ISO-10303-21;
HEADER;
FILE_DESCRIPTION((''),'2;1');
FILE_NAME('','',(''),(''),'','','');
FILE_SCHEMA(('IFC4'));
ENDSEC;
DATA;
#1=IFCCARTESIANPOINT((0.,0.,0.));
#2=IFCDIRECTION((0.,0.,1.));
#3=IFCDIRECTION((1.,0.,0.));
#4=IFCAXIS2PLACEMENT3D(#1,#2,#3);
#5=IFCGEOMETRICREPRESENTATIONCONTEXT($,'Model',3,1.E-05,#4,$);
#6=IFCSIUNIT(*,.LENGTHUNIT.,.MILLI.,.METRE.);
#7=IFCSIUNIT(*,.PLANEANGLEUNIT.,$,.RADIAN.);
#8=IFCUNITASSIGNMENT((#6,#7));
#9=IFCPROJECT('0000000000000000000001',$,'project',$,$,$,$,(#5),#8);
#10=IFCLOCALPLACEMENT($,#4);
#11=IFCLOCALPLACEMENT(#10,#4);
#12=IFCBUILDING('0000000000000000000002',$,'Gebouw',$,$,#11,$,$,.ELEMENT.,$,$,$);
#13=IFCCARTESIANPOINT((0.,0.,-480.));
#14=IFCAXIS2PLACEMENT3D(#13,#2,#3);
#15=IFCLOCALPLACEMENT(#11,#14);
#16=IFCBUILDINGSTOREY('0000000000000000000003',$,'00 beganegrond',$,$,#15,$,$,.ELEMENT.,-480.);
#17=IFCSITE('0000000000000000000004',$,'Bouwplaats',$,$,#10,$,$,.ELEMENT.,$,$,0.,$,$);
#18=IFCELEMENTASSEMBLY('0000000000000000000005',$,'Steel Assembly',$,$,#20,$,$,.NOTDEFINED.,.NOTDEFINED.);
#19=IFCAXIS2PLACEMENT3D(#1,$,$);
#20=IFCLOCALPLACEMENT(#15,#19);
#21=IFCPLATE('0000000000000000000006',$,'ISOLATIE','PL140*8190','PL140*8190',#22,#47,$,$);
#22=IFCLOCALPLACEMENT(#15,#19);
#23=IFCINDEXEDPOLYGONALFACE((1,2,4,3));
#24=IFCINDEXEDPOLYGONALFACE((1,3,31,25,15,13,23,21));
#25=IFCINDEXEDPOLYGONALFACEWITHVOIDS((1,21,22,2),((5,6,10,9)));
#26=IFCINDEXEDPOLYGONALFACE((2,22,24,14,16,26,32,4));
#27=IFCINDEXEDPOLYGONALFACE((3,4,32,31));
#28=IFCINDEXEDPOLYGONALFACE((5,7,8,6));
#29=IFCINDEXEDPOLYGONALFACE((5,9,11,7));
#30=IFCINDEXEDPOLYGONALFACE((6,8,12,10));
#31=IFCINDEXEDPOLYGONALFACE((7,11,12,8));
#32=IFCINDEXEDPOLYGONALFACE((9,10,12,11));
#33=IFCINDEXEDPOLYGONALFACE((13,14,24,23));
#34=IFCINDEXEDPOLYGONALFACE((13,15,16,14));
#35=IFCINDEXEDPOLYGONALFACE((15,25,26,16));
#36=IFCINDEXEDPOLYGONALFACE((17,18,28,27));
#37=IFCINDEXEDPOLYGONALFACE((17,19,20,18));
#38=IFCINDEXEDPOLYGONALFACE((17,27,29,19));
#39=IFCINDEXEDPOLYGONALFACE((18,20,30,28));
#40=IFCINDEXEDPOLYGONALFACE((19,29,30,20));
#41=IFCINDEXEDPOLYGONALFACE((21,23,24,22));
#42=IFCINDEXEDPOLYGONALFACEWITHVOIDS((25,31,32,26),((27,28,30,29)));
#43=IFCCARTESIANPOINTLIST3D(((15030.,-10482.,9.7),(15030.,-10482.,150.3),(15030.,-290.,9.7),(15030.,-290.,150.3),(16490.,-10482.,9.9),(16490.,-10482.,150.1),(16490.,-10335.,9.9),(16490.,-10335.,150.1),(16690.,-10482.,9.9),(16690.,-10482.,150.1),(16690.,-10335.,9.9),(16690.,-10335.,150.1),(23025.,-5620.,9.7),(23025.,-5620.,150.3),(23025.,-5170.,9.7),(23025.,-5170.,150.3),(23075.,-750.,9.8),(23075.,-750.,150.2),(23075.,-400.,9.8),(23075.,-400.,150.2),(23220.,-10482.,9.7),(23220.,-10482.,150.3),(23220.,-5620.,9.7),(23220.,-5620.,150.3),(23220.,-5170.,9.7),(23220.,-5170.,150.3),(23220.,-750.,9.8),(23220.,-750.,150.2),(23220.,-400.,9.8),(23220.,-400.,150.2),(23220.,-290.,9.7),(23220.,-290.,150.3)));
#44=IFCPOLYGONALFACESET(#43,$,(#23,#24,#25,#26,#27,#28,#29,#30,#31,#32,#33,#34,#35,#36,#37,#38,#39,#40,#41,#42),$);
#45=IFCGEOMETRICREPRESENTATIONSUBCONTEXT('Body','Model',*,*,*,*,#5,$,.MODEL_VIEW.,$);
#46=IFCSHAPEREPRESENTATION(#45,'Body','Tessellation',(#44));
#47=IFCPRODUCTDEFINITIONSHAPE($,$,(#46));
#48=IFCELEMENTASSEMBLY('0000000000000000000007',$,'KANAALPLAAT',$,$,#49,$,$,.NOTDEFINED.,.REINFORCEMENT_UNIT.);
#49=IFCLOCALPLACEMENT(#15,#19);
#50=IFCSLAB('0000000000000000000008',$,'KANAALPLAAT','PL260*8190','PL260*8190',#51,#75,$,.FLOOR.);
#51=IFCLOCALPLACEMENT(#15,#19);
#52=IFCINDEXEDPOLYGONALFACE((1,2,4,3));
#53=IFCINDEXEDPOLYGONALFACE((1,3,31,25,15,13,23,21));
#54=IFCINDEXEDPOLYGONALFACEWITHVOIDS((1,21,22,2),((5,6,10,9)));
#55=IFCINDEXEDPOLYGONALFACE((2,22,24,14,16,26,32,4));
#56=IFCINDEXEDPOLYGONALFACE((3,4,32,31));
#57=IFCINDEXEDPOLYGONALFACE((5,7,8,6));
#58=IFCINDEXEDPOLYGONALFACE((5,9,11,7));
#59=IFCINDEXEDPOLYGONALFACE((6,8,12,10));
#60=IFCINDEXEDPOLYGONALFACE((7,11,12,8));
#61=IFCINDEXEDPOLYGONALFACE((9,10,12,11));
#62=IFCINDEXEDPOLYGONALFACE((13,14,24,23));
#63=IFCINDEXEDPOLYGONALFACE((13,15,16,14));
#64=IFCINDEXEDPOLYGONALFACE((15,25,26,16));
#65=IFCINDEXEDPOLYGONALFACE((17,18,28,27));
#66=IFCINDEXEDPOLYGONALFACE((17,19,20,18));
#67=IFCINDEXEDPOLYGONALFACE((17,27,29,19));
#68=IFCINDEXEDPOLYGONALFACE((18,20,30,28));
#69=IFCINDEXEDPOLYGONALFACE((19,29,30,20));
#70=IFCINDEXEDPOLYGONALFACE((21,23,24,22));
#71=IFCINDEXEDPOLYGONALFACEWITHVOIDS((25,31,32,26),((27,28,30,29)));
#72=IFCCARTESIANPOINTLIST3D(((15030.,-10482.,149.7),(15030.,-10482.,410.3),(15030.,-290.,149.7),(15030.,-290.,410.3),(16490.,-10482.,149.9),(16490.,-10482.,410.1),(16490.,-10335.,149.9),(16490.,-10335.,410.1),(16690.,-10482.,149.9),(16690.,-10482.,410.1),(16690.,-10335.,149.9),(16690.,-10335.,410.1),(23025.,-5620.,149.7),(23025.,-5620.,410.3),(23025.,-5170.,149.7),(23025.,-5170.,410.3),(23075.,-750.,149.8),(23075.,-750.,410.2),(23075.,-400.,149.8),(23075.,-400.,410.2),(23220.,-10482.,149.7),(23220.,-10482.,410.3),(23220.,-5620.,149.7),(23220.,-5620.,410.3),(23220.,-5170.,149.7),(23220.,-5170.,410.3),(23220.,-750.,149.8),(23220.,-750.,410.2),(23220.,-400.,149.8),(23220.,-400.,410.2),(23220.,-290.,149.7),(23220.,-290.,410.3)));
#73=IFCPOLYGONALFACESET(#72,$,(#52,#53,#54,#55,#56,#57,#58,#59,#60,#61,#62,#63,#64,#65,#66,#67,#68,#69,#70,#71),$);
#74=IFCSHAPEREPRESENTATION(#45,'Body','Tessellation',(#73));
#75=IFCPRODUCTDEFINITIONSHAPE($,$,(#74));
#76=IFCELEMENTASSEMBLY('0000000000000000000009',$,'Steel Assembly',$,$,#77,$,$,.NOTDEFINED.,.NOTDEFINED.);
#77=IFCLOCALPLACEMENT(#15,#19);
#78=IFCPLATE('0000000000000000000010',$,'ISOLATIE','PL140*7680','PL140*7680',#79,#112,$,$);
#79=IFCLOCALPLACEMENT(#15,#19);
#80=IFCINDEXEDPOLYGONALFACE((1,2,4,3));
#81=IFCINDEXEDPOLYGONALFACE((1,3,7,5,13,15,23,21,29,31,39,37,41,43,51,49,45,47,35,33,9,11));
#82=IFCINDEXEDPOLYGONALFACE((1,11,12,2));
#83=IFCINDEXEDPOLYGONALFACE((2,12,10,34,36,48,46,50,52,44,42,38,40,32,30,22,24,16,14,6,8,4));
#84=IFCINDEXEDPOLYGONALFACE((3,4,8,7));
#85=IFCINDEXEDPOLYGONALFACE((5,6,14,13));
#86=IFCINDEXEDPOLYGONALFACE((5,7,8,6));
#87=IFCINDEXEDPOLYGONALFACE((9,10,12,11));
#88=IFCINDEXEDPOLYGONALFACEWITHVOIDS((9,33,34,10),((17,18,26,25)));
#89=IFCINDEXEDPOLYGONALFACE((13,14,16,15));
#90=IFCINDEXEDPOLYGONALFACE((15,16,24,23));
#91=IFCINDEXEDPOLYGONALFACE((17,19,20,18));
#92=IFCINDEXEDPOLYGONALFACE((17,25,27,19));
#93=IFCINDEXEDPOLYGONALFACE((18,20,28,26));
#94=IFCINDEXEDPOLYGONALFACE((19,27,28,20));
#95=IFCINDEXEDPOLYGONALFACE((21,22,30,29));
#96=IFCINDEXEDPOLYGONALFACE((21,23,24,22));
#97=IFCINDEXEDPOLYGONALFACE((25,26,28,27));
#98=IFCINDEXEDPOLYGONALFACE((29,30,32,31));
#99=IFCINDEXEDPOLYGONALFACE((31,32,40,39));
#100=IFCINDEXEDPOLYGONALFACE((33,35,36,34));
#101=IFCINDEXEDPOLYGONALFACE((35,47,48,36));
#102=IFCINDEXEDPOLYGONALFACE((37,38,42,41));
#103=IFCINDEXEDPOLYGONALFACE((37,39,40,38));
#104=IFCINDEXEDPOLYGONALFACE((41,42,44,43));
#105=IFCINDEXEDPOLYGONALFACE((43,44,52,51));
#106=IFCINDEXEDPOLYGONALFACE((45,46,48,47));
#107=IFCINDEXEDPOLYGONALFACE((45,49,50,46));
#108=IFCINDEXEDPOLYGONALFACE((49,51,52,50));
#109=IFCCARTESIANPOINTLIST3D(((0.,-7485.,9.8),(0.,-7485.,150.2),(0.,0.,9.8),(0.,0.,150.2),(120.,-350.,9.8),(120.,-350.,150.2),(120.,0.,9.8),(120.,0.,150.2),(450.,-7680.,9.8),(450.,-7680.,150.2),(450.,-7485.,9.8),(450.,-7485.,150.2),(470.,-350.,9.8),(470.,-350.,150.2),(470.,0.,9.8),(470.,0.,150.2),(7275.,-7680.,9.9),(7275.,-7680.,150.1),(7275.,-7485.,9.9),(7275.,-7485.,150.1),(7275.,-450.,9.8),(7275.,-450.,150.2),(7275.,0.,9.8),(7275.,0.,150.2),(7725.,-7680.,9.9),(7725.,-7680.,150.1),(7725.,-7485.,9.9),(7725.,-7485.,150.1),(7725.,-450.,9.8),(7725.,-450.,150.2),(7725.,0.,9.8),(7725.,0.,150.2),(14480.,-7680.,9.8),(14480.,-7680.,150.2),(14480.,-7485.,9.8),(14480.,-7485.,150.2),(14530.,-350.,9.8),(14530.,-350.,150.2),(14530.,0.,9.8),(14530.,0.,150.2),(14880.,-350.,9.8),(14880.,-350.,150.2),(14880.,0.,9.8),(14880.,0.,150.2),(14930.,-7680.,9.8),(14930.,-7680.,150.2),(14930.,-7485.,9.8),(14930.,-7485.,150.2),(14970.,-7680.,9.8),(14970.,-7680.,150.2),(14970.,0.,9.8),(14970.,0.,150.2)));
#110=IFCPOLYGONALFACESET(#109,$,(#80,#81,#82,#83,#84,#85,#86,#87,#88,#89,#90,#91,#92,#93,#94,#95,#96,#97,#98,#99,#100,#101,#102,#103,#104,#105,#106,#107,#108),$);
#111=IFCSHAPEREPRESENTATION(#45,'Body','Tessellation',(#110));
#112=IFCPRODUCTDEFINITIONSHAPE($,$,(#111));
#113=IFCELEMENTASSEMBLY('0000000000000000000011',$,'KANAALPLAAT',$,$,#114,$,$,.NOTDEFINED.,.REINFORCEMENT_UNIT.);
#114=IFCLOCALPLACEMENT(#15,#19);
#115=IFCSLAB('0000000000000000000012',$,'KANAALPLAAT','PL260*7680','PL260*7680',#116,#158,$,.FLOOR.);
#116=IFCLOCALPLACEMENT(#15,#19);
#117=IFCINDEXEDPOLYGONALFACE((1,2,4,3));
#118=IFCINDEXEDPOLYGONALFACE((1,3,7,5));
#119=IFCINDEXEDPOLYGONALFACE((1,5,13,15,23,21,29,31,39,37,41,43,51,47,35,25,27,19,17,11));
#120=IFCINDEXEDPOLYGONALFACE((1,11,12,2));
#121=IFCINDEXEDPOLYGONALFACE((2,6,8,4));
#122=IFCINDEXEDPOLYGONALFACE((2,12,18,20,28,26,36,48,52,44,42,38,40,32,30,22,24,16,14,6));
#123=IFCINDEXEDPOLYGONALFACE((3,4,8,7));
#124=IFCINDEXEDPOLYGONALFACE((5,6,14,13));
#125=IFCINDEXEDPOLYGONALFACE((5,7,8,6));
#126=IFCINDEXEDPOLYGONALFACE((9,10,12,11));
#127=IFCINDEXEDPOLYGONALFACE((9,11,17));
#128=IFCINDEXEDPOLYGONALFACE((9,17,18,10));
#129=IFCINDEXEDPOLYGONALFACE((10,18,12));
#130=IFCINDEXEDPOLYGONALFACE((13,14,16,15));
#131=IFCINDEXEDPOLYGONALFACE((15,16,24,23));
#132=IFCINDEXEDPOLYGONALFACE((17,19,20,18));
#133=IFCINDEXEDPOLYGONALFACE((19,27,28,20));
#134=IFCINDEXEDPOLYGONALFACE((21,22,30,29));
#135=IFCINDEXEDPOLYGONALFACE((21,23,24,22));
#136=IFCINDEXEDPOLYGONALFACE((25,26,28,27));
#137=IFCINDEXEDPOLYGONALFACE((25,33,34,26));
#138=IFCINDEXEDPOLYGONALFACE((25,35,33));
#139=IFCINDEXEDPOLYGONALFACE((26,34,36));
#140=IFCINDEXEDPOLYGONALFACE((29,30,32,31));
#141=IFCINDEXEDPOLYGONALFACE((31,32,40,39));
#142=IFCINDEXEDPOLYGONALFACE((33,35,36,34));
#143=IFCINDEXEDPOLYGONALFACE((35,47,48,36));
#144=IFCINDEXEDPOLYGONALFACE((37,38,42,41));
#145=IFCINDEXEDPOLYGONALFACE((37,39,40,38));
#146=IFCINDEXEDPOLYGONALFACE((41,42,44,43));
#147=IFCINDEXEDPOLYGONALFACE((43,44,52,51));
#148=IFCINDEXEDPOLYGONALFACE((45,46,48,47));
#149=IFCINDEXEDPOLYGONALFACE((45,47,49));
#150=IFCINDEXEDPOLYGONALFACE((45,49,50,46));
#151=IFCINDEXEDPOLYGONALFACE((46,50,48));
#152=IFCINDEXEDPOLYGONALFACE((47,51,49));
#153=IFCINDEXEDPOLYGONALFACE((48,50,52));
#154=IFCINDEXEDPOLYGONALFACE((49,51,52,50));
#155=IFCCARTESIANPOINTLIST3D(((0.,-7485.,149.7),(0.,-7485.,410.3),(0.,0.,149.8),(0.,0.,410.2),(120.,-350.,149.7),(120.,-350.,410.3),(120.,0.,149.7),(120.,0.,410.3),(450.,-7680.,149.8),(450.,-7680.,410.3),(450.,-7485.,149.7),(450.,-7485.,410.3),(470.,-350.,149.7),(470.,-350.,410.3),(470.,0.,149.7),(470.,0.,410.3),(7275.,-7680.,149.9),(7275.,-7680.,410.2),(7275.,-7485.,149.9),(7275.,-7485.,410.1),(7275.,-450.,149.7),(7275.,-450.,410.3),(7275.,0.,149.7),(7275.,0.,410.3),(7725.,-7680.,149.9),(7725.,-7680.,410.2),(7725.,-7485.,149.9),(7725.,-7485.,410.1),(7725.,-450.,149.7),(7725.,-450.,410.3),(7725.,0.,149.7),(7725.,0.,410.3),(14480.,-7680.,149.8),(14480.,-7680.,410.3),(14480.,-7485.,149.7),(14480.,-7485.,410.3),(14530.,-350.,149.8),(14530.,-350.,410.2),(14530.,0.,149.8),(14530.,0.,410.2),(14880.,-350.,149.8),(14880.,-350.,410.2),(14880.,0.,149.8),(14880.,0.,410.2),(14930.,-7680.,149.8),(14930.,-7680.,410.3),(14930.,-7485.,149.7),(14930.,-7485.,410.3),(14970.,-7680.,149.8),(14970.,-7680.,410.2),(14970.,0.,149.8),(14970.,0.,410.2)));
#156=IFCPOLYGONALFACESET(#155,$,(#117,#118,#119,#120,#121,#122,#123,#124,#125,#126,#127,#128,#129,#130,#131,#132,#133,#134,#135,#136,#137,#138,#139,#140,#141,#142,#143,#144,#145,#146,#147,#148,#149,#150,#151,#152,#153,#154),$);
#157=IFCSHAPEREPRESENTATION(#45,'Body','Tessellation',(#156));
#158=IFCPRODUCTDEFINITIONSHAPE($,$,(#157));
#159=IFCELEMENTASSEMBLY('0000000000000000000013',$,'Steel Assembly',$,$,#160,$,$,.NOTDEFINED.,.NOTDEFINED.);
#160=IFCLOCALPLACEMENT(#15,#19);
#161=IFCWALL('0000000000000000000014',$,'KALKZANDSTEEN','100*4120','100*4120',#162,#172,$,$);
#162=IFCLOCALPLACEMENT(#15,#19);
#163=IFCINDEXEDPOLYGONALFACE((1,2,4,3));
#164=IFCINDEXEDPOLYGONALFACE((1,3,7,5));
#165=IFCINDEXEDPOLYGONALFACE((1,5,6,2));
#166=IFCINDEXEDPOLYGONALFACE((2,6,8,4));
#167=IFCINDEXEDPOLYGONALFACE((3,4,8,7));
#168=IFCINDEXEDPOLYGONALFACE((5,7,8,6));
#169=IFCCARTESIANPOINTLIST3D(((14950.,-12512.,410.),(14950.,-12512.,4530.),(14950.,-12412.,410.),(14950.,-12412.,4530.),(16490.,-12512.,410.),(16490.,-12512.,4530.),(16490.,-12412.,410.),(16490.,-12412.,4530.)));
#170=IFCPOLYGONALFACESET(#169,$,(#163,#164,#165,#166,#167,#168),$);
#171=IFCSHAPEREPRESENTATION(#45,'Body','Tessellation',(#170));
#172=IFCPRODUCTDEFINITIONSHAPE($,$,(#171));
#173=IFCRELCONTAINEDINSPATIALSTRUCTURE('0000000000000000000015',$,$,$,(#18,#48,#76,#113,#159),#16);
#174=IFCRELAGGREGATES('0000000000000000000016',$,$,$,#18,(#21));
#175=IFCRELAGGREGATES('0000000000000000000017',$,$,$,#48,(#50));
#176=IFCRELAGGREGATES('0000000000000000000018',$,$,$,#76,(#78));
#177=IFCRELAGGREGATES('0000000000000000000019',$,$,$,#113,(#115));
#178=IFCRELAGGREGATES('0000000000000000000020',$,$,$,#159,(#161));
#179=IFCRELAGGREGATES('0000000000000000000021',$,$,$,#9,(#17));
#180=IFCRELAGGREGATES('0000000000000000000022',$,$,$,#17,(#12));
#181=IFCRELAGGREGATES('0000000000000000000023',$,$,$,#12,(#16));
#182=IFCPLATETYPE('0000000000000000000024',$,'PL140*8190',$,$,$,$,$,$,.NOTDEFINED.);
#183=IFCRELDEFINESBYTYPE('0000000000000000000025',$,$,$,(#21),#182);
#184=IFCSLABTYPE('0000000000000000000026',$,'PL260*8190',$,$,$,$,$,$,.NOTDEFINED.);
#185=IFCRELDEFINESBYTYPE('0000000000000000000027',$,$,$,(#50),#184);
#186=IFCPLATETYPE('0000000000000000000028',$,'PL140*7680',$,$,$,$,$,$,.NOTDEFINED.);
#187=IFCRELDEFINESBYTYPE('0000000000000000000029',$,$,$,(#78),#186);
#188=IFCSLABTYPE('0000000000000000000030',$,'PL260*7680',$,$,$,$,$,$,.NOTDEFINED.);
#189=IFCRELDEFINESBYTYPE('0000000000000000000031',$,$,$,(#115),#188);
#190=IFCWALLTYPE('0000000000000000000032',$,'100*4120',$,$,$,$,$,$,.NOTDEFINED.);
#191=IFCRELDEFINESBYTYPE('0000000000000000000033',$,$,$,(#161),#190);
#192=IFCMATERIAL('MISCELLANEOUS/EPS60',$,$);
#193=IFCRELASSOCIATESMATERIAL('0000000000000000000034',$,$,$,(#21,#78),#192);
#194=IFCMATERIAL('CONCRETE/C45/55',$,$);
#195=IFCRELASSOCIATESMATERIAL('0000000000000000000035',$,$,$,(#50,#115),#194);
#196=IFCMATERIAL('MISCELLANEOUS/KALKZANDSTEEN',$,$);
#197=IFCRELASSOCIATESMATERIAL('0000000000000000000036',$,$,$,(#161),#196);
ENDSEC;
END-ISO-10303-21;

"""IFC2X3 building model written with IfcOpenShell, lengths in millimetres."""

from ifc_helpers import new_model, si_unit, frame, frame_2d, origin_with_axes, place, context, subcontext, project, spatial, polyline, rectangle, outline, extrude, boolean, material, type_object, element, aggregate, save


model = new_model("IFC2X3")

# Units and contexts
model_context = context("Model", 3, precision=1e-05, world=origin_with_axes())
body_context = subcontext(model_context, "Body", "Model", "MODEL_VIEW")
ifc_project = project(units=[si_unit("LENGTHUNIT", "METRE", prefix="MILLI"), si_unit("PLANEANGLEUNIT", "RADIAN")], contexts=[model_context])

# Site, building, storey
site_placement = place(None, origin_with_axes())
site = spatial("IfcSite", under=ifc_project, at=site_placement, Name="Bouwplaats", CompositionType="ELEMENT", RefElevation=0.0)
building_placement = place(site_placement, origin_with_axes())
building = spatial("IfcBuilding", under=site, at=building_placement, Name="Gebouw", CompositionType="ELEMENT")
storey_placement = place(building_placement, frame((0.0, 0.0, -480.0), z_axis=(0.0, 0.0, 1.0), x_axis=(1.0, 0.0, 0.0)))
storey = spatial("IfcBuildingStorey", under=building, at=storey_placement, Name="00 beganegrond", CompositionType="ELEMENT", Elevation=-480.0)

# Element assembly, plate
assembly_1_placement = place(storey_placement, origin_with_axes())
assembly_1 = element("IfcElementAssembly", 1, at=assembly_1_placement, inside=storey, Name="Steel Assembly", AssemblyPlace="NOTDEFINED", PredefinedType="NOTDEFINED")
ifc_material_1 = material(Name="MISCELLANEOUS/EPS60")
plate_type_1 = type_object("IfcPlateType", Name="PL140*8190", PredefinedType="NOTDEFINED")
plate_1_placement = place(assembly_1_placement, frame((15030.0, -10482.0, 80.0), z_axis=(0.0, 0.0, 1.0), x_axis=(1.0, 0.0, 0.0)))
plate_1 = element("IfcPlate", 2, at=plate_1_placement, type_object=plate_type_1, material=ifc_material_1, Name="ISOLATIE", Description="PL140*8190", ObjectType="PL140*8190", context=body_context, shape_type="CSG", body=[
    boolean("DIFFERENCE", boolean("DIFFERENCE", boolean("DIFFERENCE", extrude(outline(polyline([(0.0, 0.0), (8190.0, 0.0), (8190.0, 10192.0), (0.0, 10192.0), (0.0, 0.0)])), frame((0.0, 0.0, -70.3), z_axis=(0.0, 0.0, 1.0), x_axis=(1.0, 0.0, 0.0)), (0.0, 0.0, 1.0), 140.6), extrude(outline(polyline([(0.0, 0.0), (450.0, 0.0), (450.0, 450.0), (0.0, 450.0), (0.0, 0.0)])), frame((7995.0, 5312.0, -70.3), z_axis=(0.0, 0.0, 1.0), x_axis=(0.0, -1.0, 0.0)), (0.0, 0.0, 1.0), 140.6)), extrude(outline(polyline([(0.0, 0.0), (350.0, 0.0), (350.0, 350.0), (0.0, 350.0), (0.0, 0.0)])), frame((8045.0, 10082.0, -70.2), z_axis=(0.0, 0.0, 1.0), x_axis=(0.0, -1.0, 0.0)), (0.0, 0.0, 1.0), 140.4)), extrude(outline(polyline([(0.0, 0.0), (6835.0, 0.0), (6835.0, 200.0), (0.0, 200.0), (0.0, 0.0)])), frame((1460.0, 147.0, -70.1), z_axis=(0.0, 0.0, 1.0), x_axis=(0.0, -1.0, 0.0)), (0.0, 0.0, 1.0), 140.2)),
])
aggregate(assembly_1, [plate_1])

# Element assembly, slab
assembly_2_placement = place(storey_placement, origin_with_axes())
assembly_2 = element("IfcElementAssembly", 3, at=assembly_2_placement, inside=storey, Name="KANAALPLAAT", AssemblyPlace="NOTDEFINED", PredefinedType="REINFORCEMENT_UNIT")
ifc_material_2 = material(Name="CONCRETE/C45/55")
slab_type_1 = type_object("IfcSlabType", Name="PL260*8190", PredefinedType="NOTDEFINED")
slab_1_placement = place(assembly_2_placement, frame((15030.0, -10482.0, 280.0), z_axis=(0.0, 0.0, 1.0), x_axis=(1.0, 0.0, 0.0)))
slab_1 = element("IfcSlab", 4, at=slab_1_placement, type_object=slab_type_1, material=ifc_material_2, Name="KANAALPLAAT", Description="PL260*8190", ObjectType="PL260*8190", PredefinedType="FLOOR", context=body_context, shape_type="CSG", body=[
    boolean("DIFFERENCE", boolean("DIFFERENCE", boolean("DIFFERENCE", extrude(outline(polyline([(0.0, 0.0), (8190.0, 0.0), (8190.0, 10192.0), (0.0, 10192.0), (0.0, 0.0)])), frame((0.0, 0.0, -130.3), z_axis=(0.0, 0.0, 1.0), x_axis=(1.0, 0.0, 0.0)), (0.0, 0.0, 1.0), 260.6), extrude(outline(polyline([(0.0, 0.0), (450.0, 0.0), (450.0, 450.0), (0.0, 450.0), (0.0, 0.0)])), frame((7995.0, 5312.0, -130.3), z_axis=(0.0, 0.0, 1.0), x_axis=(0.0, -1.0, 0.0)), (0.0, 0.0, 1.0), 260.6)), extrude(outline(polyline([(0.0, 0.0), (350.0, 0.0), (350.0, 350.0), (0.0, 350.0), (0.0, 0.0)])), frame((8045.0, 10082.0, -130.2), z_axis=(0.0, 0.0, 1.0), x_axis=(0.0, -1.0, 0.0)), (0.0, 0.0, 1.0), 260.4)), extrude(outline(polyline([(0.0, 0.0), (6835.0, 0.0), (6835.0, 200.0), (0.0, 200.0), (0.0, 0.0)])), frame((1460.0, 147.0, -130.1), z_axis=(0.0, 0.0, 1.0), x_axis=(0.0, -1.0, 0.0)), (0.0, 0.0, 1.0), 260.2)),
])
aggregate(assembly_2, [slab_1])

# Element assembly, plate
assembly_3_placement = place(storey_placement, origin_with_axes())
assembly_3 = element("IfcElementAssembly", 5, at=assembly_3_placement, inside=storey, Name="Steel Assembly", AssemblyPlace="NOTDEFINED", PredefinedType="NOTDEFINED")
plate_type_2 = type_object("IfcPlateType", Name="PL140*7680", PredefinedType="NOTDEFINED")
plate_2_placement = place(assembly_3_placement, frame((14970.0, -7680.0, 80.0), z_axis=(0.0, 0.0, 1.0), x_axis=(0.0, 1.0, 0.0)))
plate_2 = element("IfcPlate", 6, at=plate_2_placement, type_object=plate_type_2, material=ifc_material_1, Name="ISOLATIE", Description="PL140*7680", ObjectType="PL140*7680", context=body_context, shape_type="CSG", body=[
    boolean("DIFFERENCE", boolean("DIFFERENCE", boolean("DIFFERENCE", boolean("DIFFERENCE", boolean("DIFFERENCE", boolean("DIFFERENCE", extrude(outline(polyline([(0.0, 0.0), (7680.0, 0.0), (7680.0, 14970.0), (0.0, 14970.0), (0.0, 0.0)])), frame((0.0, 0.0, -70.2), z_axis=(0.0, 0.0, 1.0), x_axis=(1.0, 0.0, 0.0)), (0.0, 0.0, 1.0), 140.4), extrude(outline(polyline([(0.0, 0.0), (450.0, 0.0), (450.0, 450.0), (0.0, 450.0), (0.0, 0.0)])), frame((-255.0, 7695.0, -70.1), z_axis=(0.0, 0.0, 1.0), x_axis=(0.0, -1.0, 0.0)), (0.0, 0.0, 1.0), 140.2)), extrude(outline(polyline([(0.0, 0.0), (350.0, 0.0), (350.0, 350.0), (0.0, 350.0), (0.0, 0.0)])), frame((7330.0, 440.0, -70.2), z_axis=(0.0, 0.0, 1.0), x_axis=(0.0, -1.0, 0.0)), (0.0, 0.0, 1.0), 140.4)), extrude(outline(polyline([(0.0, 0.0), (450.0, 0.0), (450.0, 450.0), (0.0, 450.0), (0.0, 0.0)])), frame((7230.0, 7695.0, -70.3), z_axis=(0.0, 0.0, 1.0), x_axis=(0.0, -1.0, 0.0)), (0.0, 0.0, 1.0), 140.6)), extrude(outline(polyline([(0.0, 0.0), (350.0, 0.0), (350.0, 350.0), (0.0, 350.0), (0.0, 0.0)])), frame((7330.0, 14850.0, -70.3), z_axis=(0.0, 0.0, 1.0), x_axis=(0.0, -1.0, 0.0)), (0.0, 0.0, 1.0), 140.6)), extrude(outline(polyline([(0.0, 0.0), (450.0, 0.0), (450.0, 450.0), (0.0, 450.0), (0.0, 0.0)])), frame((-255.0, 14970.0, -70.3), z_axis=(0.0, 0.0, 1.0), x_axis=(0.0, -1.0, 0.0)), (0.0, 0.0, 1.0), 140.6)), extrude(outline(polyline([(0.0, 0.0), (450.0, 0.0), (450.0, 450.0), (0.0, 450.0), (0.0, 0.0)])), frame((-255.0, 490.0, -70.3), z_axis=(0.0, 0.0, 1.0), x_axis=(0.0, -1.0, 0.0)), (0.0, 0.0, 1.0), 140.6)),
])
aggregate(assembly_3, [plate_2])

# Element assembly, slab
assembly_4_placement = place(storey_placement, origin_with_axes())
assembly_4 = element("IfcElementAssembly", 7, at=assembly_4_placement, inside=storey, Name="KANAALPLAAT", AssemblyPlace="NOTDEFINED", PredefinedType="REINFORCEMENT_UNIT")
slab_type_2 = type_object("IfcSlabType", Name="PL260*7680", PredefinedType="NOTDEFINED")
slab_2_placement = place(assembly_4_placement, frame((14970.0, -7680.0, 280.0), z_axis=(0.0, 0.0, 1.0), x_axis=(0.0, 1.0, 0.0)))
slab_2 = element("IfcSlab", 8, at=slab_2_placement, type_object=slab_type_2, material=ifc_material_2, Name="KANAALPLAAT", Description="PL260*7680", ObjectType="PL260*7680", PredefinedType="FLOOR", context=body_context, shape_type="CSG", body=[
    boolean("DIFFERENCE", boolean("DIFFERENCE", boolean("DIFFERENCE", boolean("DIFFERENCE", boolean("DIFFERENCE", boolean("DIFFERENCE", extrude(outline(polyline([(0.0, 0.0), (7680.0, 0.0), (7680.0, 14970.0), (0.0, 14970.0), (0.0, 0.0)])), frame((0.0, 0.0, -130.2), z_axis=(0.0, 0.0, 1.0), x_axis=(1.0, 0.0, 0.0)), (0.0, 0.0, 1.0), 260.4), extrude(outline(polyline([(0.0, 0.0), (450.0, 0.0), (450.0, 450.0), (0.0, 450.0), (0.0, 0.0)])), frame((-255.0, 7695.0, -130.1), z_axis=(0.0, 0.0, 1.0), x_axis=(0.0, -1.0, 0.0)), (0.0, 0.0, 1.0), 260.2)), extrude(outline(polyline([(0.0, 0.0), (350.0, 0.0), (350.0, 350.0), (0.0, 350.0), (0.0, 0.0)])), frame((7330.0, 440.0, -130.2), z_axis=(0.0, 0.0, 1.0), x_axis=(0.0, -1.0, 0.0)), (0.0, 0.0, 1.0), 260.4)), extrude(outline(polyline([(0.0, 0.0), (450.0, 0.0), (450.0, 450.0), (0.0, 450.0), (0.0, 0.0)])), frame((7230.0, 7695.0, -130.3), z_axis=(0.0, 0.0, 1.0), x_axis=(0.0, -1.0, 0.0)), (0.0, 0.0, 1.0), 260.6)), extrude(outline(polyline([(0.0, 0.0), (350.0, 0.0), (350.0, 350.0), (0.0, 350.0), (0.0, 0.0)])), frame((7330.0, 14850.0, -130.3), z_axis=(0.0, 0.0, 1.0), x_axis=(0.0, -1.0, 0.0)), (0.0, 0.0, 1.0), 260.6)), extrude(outline(polyline([(0.0, 0.0), (450.0, 0.0), (450.0, 450.0), (0.0, 450.0), (0.0, 0.0)])), frame((-255.0, 14970.0, -130.3), z_axis=(0.0, 0.0, 1.0), x_axis=(0.0, -1.0, 0.0)), (0.0, 0.0, 1.0), 260.6)), extrude(outline(polyline([(0.0, 0.0), (450.0, 0.0), (450.0, 450.0), (0.0, 450.0), (0.0, 0.0)])), frame((-255.0, 490.0, -130.3), z_axis=(0.0, 0.0, 1.0), x_axis=(0.0, -1.0, 0.0)), (0.0, 0.0, 1.0), 260.6)),
])
aggregate(assembly_4, [slab_2])

# Element assembly, wall
assembly_5_placement = place(storey_placement, origin_with_axes())
assembly_5 = element("IfcElementAssembly", 9, at=assembly_5_placement, inside=storey, Name="Steel Assembly", AssemblyPlace="NOTDEFINED", PredefinedType="NOTDEFINED")
ifc_material_3 = material(Name="MISCELLANEOUS/KALKZANDSTEEN")
wall_type_1 = type_object("IfcWallType", Name="100*4120", PredefinedType="NOTDEFINED")
wall_1_placement = place(assembly_5_placement, frame((14950.0, -12462.0, 410.0), z_axis=(0.0, 0.0, 1.0), x_axis=(1.0, 0.0, 0.0)))
wall_1 = element("IfcWall", 10, at=wall_1_placement, type_object=wall_type_1, material=ifc_material_3, Name="KALKZANDSTEEN", Description="100*4120", ObjectType="100*4120", context=body_context, shape_type="SweptSolid", body=[
    extrude(rectangle(XDim=1540.0, YDim=100.0, at=frame_2d((0.0, 770.0), x_axis=(0.0, -1.0))), frame((0.0, 0.0, 0.0), z_axis=(0.0, 0.0, 1.0), x_axis=(0.0, -1.0, 0.0)), (0.0, 0.0, 1.0), 4120.0),
])
aggregate(assembly_5, [wall_1])

save(model, "model.ifc")
